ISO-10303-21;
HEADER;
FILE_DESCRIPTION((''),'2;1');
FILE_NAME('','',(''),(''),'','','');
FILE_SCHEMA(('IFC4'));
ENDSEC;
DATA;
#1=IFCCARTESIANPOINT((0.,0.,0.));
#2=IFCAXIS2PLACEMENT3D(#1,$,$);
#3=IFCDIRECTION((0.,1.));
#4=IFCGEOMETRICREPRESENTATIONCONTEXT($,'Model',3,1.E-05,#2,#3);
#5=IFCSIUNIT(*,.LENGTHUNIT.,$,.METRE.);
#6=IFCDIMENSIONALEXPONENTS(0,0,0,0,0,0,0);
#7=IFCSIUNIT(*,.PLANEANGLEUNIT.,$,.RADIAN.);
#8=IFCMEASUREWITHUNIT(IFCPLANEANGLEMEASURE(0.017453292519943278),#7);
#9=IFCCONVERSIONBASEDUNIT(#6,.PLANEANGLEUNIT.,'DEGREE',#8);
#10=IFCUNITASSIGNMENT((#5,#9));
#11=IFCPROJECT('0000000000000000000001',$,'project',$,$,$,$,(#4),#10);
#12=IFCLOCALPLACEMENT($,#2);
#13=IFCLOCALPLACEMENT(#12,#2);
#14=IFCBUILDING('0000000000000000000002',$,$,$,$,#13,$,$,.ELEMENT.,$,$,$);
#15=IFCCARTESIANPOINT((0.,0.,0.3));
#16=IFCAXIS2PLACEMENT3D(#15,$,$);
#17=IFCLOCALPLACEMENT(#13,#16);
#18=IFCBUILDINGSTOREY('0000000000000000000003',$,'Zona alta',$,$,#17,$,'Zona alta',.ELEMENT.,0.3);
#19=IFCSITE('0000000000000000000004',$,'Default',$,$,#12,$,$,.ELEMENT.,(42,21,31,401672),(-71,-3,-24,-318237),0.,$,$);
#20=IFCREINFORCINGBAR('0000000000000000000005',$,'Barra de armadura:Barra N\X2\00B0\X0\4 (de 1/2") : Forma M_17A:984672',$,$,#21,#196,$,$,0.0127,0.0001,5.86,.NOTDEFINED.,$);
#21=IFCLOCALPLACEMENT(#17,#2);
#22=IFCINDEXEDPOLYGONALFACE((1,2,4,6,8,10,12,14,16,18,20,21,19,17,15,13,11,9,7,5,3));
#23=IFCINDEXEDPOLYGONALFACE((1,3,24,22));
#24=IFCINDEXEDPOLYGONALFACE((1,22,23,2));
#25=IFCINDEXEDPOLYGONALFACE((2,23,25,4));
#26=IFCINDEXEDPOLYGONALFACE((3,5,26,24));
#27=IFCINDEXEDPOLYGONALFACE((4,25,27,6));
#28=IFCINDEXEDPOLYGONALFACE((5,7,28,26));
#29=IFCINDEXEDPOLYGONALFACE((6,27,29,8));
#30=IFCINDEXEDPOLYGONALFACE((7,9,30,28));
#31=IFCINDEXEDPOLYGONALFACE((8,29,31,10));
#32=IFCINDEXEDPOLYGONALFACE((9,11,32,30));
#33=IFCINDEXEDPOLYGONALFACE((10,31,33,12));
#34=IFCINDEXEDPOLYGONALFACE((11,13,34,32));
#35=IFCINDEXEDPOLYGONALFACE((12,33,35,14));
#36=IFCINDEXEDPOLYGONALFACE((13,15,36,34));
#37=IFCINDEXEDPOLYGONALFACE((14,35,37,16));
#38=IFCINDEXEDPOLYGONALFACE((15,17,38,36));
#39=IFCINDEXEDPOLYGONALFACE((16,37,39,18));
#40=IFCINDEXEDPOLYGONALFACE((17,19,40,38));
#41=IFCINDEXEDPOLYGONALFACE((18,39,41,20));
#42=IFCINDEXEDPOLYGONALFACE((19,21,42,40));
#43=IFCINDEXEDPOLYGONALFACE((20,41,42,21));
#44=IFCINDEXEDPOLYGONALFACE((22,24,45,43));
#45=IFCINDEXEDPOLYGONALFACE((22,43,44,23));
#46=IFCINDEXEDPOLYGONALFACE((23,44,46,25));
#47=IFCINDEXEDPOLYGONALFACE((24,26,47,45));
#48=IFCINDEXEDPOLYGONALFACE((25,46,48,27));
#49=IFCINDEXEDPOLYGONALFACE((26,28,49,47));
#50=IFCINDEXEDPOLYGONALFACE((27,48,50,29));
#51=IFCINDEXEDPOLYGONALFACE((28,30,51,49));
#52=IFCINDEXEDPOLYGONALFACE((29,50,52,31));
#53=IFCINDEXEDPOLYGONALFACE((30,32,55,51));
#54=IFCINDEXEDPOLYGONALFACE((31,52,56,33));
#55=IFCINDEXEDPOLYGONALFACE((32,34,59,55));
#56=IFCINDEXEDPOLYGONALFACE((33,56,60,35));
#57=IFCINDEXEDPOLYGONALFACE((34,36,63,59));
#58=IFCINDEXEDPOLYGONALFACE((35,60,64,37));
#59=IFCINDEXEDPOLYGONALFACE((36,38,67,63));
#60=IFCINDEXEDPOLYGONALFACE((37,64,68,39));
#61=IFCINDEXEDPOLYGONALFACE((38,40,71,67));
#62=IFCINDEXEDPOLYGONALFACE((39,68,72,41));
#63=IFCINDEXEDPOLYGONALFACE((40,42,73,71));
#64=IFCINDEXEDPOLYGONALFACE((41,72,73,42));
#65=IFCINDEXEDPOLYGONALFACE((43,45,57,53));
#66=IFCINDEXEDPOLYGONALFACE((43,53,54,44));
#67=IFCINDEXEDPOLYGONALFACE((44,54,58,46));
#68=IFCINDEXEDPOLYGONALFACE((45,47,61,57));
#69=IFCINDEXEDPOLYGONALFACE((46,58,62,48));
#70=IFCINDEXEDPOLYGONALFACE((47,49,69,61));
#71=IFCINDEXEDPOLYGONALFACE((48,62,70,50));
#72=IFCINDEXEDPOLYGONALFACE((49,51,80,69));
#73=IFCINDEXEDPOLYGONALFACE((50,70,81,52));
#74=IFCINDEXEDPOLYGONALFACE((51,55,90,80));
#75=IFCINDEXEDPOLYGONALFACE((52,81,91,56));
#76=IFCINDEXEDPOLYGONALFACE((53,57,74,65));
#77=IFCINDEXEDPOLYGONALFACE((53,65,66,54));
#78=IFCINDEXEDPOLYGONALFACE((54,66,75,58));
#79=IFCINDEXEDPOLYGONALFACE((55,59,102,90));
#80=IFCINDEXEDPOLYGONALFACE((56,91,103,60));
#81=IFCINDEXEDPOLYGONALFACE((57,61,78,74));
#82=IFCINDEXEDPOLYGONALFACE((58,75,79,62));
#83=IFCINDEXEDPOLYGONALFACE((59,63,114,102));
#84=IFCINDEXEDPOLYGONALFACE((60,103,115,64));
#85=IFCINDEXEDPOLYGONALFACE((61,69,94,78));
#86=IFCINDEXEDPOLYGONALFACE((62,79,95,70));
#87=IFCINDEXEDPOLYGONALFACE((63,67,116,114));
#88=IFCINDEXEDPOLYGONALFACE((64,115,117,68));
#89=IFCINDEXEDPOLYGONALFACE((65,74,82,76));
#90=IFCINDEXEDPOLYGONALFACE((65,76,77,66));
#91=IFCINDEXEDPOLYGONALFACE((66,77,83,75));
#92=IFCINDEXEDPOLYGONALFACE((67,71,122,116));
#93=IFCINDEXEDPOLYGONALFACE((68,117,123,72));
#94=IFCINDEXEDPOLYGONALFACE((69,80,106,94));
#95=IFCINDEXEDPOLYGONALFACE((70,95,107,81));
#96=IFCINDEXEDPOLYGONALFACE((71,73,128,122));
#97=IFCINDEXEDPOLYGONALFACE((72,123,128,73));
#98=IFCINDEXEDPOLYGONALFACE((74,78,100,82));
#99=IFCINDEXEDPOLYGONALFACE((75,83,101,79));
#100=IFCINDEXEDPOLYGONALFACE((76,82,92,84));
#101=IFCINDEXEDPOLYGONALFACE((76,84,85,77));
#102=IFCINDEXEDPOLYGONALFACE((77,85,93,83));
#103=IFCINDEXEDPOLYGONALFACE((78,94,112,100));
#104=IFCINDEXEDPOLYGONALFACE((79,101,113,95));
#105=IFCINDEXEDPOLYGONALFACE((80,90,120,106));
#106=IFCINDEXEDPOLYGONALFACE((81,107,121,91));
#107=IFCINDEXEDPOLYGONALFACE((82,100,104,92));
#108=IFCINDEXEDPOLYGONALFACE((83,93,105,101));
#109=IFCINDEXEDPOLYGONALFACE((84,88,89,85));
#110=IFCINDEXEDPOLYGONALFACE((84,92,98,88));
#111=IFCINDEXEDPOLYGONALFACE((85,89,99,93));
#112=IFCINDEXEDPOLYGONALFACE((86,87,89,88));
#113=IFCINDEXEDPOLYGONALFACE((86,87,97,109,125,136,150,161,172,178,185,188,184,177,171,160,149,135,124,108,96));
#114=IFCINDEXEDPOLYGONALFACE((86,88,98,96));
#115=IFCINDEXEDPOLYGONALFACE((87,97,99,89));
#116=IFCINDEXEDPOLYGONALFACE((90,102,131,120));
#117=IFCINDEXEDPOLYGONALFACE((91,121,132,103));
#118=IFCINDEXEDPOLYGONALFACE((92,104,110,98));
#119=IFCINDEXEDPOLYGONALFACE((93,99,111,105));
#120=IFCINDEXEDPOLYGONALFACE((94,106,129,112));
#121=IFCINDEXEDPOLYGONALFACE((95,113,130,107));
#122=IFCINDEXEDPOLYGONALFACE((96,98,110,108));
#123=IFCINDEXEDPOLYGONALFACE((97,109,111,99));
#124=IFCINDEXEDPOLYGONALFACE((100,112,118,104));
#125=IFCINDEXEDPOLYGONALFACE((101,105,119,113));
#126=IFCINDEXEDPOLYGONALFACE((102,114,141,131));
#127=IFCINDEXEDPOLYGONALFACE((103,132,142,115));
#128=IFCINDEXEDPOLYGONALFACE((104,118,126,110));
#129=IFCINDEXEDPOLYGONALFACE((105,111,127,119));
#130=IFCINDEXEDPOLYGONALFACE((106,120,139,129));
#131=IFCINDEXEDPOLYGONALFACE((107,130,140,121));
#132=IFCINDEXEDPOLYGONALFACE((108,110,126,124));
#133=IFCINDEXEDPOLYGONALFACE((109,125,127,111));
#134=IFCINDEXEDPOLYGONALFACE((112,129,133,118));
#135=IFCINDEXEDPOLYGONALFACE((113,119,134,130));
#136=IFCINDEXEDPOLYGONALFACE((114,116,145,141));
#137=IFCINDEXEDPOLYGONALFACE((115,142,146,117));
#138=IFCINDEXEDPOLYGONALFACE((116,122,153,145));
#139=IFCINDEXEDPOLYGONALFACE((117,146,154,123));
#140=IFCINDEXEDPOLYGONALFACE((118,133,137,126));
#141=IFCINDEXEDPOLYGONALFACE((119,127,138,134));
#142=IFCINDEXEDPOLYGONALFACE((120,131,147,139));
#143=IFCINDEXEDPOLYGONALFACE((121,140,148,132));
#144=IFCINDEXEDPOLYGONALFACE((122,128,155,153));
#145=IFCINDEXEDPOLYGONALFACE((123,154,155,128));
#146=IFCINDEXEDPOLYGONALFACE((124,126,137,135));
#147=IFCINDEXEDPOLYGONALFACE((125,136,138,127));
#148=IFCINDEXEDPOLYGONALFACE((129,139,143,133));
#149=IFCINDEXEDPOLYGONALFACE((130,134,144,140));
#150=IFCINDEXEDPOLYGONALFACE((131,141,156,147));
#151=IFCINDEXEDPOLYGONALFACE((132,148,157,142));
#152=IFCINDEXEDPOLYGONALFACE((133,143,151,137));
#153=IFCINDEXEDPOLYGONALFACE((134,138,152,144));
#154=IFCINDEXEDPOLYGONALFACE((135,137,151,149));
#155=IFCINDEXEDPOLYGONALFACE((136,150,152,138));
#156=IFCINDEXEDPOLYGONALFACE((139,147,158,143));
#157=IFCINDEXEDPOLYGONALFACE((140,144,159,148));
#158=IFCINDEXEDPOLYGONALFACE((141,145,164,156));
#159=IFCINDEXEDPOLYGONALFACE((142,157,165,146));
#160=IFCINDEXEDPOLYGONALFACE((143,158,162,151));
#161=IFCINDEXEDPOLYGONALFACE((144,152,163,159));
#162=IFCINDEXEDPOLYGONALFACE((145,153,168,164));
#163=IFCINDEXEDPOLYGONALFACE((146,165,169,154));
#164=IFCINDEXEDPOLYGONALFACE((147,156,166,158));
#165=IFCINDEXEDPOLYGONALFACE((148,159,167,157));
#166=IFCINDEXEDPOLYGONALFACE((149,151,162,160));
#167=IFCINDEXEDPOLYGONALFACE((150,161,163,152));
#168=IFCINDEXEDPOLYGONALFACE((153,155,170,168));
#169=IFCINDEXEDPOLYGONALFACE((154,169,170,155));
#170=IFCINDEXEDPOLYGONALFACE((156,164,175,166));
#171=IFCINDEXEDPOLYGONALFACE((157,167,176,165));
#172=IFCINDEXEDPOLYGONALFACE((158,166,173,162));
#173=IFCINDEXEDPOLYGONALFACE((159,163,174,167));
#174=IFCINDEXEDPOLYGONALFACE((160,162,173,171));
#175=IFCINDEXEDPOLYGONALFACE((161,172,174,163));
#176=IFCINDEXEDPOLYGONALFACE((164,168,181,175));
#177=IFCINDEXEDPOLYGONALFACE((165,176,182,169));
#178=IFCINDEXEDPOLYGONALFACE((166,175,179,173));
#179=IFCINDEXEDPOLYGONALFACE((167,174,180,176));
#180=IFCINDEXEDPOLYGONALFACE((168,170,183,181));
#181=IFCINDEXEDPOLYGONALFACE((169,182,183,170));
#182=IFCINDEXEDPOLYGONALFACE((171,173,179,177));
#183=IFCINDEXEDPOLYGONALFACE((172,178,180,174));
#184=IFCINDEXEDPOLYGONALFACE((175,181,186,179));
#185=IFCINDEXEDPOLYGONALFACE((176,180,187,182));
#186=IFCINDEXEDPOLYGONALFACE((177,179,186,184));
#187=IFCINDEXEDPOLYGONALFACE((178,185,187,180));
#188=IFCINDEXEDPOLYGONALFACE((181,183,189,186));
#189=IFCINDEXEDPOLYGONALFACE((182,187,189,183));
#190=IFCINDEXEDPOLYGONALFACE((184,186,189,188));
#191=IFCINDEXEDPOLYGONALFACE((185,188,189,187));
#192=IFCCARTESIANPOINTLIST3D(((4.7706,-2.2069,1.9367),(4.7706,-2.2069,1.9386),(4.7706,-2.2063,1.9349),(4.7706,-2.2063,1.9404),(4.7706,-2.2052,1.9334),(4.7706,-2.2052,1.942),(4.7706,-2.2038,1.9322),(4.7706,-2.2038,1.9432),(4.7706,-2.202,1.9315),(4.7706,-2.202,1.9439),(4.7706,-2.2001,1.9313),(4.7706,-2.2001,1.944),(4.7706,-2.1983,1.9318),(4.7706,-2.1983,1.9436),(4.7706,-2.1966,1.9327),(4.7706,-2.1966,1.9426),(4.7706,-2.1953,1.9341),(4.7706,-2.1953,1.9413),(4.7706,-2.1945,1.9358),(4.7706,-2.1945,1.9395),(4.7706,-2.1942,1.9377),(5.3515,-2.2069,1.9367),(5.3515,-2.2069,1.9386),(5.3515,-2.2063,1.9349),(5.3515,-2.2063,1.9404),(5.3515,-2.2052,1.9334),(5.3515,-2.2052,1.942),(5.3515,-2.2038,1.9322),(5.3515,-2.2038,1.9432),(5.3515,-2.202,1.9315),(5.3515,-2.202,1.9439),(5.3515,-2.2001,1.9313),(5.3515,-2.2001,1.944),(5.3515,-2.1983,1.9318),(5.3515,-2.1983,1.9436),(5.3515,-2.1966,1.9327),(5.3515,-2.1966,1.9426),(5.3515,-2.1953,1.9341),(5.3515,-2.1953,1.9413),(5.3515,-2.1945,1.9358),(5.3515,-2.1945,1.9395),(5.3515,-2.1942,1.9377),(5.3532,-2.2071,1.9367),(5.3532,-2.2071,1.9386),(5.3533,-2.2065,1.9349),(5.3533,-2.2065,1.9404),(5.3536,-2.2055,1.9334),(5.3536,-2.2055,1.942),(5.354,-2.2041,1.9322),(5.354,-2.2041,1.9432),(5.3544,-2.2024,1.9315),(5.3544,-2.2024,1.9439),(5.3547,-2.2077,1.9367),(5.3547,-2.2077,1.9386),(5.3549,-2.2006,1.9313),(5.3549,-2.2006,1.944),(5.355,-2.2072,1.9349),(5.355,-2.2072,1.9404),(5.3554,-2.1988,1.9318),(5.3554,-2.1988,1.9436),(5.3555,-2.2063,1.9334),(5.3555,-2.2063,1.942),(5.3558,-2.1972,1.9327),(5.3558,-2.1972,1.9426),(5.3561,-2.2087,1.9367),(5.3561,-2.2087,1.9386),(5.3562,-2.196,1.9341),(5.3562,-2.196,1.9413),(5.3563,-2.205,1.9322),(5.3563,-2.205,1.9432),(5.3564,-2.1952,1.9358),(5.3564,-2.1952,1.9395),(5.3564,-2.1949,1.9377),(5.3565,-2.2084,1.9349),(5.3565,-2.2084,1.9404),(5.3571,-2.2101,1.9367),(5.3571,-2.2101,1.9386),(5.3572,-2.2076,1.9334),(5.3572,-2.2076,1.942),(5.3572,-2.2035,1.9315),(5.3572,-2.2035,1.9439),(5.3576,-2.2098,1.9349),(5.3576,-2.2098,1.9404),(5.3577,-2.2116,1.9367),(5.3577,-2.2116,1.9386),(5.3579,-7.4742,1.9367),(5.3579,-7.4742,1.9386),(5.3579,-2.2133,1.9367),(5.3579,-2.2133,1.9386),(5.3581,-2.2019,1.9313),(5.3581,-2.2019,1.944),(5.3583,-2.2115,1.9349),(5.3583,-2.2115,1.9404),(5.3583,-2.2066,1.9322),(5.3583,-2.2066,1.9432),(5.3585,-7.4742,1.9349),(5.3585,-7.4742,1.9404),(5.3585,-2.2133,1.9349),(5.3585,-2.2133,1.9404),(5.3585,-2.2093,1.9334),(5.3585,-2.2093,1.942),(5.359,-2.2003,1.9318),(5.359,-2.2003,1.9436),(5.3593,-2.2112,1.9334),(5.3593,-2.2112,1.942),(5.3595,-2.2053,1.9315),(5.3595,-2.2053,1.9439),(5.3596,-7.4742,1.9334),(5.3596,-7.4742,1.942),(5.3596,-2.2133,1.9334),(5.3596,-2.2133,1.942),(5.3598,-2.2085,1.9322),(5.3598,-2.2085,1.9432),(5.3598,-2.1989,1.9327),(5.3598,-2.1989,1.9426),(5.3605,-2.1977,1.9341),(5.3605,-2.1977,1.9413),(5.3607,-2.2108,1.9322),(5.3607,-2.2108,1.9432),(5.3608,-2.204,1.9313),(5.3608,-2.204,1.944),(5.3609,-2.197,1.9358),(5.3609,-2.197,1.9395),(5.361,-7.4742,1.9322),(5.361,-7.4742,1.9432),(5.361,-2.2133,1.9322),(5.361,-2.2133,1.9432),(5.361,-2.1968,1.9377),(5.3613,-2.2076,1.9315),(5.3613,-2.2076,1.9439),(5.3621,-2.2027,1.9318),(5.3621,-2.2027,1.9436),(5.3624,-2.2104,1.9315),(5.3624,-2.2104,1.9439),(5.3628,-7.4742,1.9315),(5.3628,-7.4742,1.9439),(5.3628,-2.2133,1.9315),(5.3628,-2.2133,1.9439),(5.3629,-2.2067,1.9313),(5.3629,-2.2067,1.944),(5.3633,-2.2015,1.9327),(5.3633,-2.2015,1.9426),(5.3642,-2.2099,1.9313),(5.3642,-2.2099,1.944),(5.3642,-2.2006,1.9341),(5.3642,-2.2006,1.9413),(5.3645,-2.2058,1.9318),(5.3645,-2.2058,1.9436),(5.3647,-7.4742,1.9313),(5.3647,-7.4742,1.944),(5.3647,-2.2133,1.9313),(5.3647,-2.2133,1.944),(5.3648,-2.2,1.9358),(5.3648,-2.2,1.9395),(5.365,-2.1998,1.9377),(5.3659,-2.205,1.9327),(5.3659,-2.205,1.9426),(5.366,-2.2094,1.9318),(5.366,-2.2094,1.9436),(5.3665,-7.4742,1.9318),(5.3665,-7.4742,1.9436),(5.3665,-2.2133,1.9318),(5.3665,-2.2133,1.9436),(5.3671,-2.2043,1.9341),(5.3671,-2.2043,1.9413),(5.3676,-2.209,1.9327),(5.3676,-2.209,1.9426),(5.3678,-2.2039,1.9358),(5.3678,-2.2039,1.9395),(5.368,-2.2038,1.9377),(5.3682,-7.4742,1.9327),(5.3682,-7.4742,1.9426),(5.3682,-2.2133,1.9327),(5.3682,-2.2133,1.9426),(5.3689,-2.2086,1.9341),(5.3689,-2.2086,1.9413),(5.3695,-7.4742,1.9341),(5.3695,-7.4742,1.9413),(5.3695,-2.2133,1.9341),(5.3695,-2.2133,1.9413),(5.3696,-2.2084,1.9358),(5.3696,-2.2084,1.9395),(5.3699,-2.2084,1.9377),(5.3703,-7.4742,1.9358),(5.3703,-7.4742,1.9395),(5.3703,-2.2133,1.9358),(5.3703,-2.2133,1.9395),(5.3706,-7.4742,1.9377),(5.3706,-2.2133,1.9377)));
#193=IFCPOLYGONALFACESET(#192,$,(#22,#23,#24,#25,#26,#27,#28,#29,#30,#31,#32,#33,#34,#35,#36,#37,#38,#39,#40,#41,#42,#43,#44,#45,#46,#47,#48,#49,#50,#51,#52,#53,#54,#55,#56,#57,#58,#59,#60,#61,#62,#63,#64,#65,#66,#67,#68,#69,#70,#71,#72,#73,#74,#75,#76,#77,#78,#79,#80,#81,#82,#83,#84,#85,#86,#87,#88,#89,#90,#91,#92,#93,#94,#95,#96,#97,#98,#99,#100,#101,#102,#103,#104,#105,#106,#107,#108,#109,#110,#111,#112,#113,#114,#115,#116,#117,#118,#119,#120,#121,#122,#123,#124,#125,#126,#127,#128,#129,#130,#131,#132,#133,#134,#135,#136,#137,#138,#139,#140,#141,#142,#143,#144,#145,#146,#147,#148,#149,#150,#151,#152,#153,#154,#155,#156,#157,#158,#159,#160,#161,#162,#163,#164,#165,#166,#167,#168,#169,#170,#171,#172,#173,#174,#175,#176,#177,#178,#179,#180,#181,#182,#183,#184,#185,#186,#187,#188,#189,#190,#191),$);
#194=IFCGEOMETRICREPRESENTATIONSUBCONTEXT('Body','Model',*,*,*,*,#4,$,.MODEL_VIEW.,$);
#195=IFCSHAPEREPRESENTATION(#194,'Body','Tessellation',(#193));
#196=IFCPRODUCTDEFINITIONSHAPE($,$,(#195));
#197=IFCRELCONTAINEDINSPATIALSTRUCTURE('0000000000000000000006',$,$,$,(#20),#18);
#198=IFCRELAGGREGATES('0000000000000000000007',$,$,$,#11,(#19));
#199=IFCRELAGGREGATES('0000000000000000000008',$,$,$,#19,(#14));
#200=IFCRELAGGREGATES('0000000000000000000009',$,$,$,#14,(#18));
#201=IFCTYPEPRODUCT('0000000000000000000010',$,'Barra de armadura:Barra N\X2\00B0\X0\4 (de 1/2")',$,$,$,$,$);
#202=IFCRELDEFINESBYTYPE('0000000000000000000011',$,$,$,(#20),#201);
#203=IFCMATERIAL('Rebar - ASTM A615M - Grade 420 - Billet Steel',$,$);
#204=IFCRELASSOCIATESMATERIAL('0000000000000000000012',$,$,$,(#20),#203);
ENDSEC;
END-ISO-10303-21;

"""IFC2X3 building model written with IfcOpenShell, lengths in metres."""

from ifc_helpers import new_model, entity, si_unit, converted_unit, direction, frame, origin, place, context, subcontext, project, spatial, material, type_object, element, save


model = new_model("IFC2X3")

# Units and contexts
model_context = context("Model", 3, precision=1e-05, world=origin(), true_north=direction((0.0, 1.0)))
body_context = subcontext(model_context, "Body", "Model", "MODEL_VIEW")
ifc_project = project(units=[si_unit("LENGTHUNIT", "METRE"), converted_unit("PLANEANGLEUNIT", "DEGREE", entity("IfcPlaneAngleMeasure", 0.017453292519943278), si_unit("PLANEANGLEUNIT", "RADIAN"), dimensions=[0, 0, 0, 0, 0, 0, 0])], contexts=[model_context])

# Site, building, storey
site_placement = place(None, origin())
site = spatial("IfcSite", under=ifc_project, at=site_placement, Name="Default", CompositionType="ELEMENT", RefLatitude=(42, 21, 31, 401672), RefLongitude=(-71, -3, -24, -318237), RefElevation=0.0)
building_placement = place(site_placement, origin())
building = spatial("IfcBuilding", under=site, at=building_placement, CompositionType="ELEMENT")
storey_placement = place(building_placement, frame((0.0, 0.0, 0.3)))
storey = spatial("IfcBuildingStorey", under=building, at=storey_placement, Name="Zona alta", LongName="Zona alta", CompositionType="ELEMENT", Elevation=0.3)

# Reinforcing bar
ifc_material_1 = material(Name="Rebar - ASTM A615M - Grade 420 - Billet Steel")
type_product_1 = type_object("IfcTypeProduct", Name="Barra de armadura:Barra N°4 (de 1/2\")")
reinforcing_bar_1_placement = place(storey_placement, origin())
element("IfcReinforcingBar", 1, at=reinforcing_bar_1_placement, inside=storey, type_object=type_product_1, material=ifc_material_1, Name="Barra de armadura:Barra N°4 (de 1/2\") : Forma M_17A:984672", BarLength=5.86, BarRole="NOTDEFINED", CrossSectionArea=0.0001, NominalDiameter=0.0127, context=body_context, shape_type="AdvancedSweptSolid", body=[
    entity("IfcSweptDiskSolid", entity("IfcCompositeCurve", [entity("IfcCompositeCurveSegment", "CONTINUOUS", True, entity("IfcPolyline", [entity("IfcCartesianPoint", [5.3642, -7.4742, 1.9377]), entity("IfcCartesianPoint", [5.3642, -2.2133, 1.9377])])), entity("IfcCompositeCurveSegment", "CONTINUOUS", True, entity("IfcTrimmedCurve", entity("IfcCircle", entity("IfcAxis2Placement3D", entity("IfcCartesianPoint", [5.3515, -2.2133, 1.9377]), entity("IfcDirection", [0.0, 0.0, 1.0]), entity("IfcDirection", [0.0, 1.0, 0.0])), 0.0127), [entity("IfcParameterValue", 270.0)], [entity("IfcParameterValue", 360.0)], True, "PARAMETER")), entity("IfcCompositeCurveSegment", "CONTINUOUS", True, entity("IfcPolyline", [entity("IfcCartesianPoint", [5.3515, -2.2006, 1.9377]), entity("IfcCartesianPoint", [4.7706, -2.2006, 1.9377])]))], False), 0.0063, None, 0.0, 92.0),
])

save(model, "model.ifc")
